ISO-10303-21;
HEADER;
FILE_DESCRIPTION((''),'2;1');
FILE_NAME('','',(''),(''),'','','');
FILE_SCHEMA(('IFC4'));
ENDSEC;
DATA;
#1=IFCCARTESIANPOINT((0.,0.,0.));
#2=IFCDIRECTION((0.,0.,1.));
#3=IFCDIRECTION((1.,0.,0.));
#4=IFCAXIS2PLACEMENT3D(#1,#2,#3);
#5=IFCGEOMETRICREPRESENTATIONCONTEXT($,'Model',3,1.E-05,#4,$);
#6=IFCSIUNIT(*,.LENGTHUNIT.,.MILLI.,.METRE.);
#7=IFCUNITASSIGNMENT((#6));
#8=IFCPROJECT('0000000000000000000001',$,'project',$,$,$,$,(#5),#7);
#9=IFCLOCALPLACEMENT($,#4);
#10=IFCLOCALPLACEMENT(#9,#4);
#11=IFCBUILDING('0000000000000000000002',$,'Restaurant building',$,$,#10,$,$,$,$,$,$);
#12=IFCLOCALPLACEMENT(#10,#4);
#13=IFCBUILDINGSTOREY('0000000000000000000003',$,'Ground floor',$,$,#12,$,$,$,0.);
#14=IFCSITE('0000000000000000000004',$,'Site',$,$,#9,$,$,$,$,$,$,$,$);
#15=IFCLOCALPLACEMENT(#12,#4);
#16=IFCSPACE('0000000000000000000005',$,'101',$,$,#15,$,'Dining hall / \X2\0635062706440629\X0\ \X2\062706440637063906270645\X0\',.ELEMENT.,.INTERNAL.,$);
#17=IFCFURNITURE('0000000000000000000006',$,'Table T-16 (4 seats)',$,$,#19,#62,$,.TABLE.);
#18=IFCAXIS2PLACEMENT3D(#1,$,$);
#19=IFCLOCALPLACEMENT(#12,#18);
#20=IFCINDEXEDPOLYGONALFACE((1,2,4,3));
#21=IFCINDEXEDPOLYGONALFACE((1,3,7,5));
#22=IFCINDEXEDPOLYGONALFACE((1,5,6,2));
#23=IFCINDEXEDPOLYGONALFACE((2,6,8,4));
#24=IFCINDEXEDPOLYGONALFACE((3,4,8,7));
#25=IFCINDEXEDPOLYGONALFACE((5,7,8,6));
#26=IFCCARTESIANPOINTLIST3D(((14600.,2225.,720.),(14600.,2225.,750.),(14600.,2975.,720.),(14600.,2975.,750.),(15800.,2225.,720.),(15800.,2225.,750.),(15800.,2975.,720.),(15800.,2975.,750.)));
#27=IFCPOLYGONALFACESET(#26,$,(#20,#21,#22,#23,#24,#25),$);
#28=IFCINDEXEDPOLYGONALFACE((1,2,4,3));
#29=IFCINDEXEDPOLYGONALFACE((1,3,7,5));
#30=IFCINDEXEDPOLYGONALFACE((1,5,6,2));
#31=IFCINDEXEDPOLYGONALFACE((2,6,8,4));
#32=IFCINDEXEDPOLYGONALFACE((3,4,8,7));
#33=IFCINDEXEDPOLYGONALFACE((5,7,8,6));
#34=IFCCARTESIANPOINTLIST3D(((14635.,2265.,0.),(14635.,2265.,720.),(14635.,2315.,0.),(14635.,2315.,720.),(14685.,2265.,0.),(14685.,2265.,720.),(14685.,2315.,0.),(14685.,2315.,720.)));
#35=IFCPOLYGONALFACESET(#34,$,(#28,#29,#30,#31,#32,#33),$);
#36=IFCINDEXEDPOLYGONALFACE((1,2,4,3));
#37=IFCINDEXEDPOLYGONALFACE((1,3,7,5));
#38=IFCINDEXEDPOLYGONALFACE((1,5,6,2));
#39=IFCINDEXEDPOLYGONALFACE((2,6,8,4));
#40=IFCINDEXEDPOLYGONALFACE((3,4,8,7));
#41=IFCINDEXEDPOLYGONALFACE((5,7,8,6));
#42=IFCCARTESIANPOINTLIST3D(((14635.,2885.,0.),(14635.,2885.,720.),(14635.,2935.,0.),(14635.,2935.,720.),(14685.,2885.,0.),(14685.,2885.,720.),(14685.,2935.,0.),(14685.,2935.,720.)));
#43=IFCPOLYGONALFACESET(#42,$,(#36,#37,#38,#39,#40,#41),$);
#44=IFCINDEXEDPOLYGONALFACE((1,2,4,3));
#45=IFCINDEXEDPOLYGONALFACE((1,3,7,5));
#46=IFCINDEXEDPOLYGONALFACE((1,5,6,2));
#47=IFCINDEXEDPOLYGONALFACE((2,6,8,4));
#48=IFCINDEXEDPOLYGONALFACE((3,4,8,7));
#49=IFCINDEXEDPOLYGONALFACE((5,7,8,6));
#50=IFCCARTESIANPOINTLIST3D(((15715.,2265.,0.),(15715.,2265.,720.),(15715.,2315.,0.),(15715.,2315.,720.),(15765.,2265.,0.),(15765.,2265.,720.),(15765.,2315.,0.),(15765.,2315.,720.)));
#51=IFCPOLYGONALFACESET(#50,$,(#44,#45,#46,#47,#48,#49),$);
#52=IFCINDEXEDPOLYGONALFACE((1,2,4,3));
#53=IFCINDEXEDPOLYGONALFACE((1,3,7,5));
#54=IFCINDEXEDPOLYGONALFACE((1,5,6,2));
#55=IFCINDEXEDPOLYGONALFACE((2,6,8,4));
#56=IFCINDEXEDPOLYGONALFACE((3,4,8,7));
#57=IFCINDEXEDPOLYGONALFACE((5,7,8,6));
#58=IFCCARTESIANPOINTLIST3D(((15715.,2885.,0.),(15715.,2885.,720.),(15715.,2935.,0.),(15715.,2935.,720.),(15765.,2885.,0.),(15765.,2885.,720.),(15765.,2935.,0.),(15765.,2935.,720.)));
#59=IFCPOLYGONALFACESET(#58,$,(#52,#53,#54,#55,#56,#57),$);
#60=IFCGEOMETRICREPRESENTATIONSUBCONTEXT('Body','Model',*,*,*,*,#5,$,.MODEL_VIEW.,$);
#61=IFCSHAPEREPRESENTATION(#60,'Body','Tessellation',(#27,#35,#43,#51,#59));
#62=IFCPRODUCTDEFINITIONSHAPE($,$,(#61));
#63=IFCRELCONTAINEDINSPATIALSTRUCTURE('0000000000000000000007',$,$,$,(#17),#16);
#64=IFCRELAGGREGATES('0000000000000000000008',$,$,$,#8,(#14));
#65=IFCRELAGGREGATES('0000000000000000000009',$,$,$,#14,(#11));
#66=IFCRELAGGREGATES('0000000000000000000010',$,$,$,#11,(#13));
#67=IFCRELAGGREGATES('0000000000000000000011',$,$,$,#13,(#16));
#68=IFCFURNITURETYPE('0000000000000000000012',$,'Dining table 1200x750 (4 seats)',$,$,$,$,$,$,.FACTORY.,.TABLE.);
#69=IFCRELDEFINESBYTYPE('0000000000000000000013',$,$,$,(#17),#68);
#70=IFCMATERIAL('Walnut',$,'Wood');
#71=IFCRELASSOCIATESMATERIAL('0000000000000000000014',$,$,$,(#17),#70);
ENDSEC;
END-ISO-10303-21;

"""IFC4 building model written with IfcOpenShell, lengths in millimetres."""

from ifc_helpers import new_model, si_unit, frame, origin, origin_with_axes, origin_2d, place, context, subcontext, project, spatial, rectangle, extrude, source, transform, mapped, material, type_object, type_shapes, element, save


model = new_model("IFC4")

# Units and contexts
model_context = context("Model", 3, precision=1e-05, world=origin_with_axes())
body_context = subcontext(model_context, "Body", "Model", "MODEL_VIEW")
ifc_project = project(units=[si_unit("LENGTHUNIT", "METRE", prefix="MILLI")], contexts=[model_context])

# Site, building, storey
site_placement = place(None, origin_with_axes())
site = spatial("IfcSite", under=ifc_project, at=site_placement, Name="Site")
building_placement = place(site_placement, origin_with_axes())
building = spatial("IfcBuilding", under=site, at=building_placement, Name="Restaurant building")
storey_placement = place(building_placement, origin_with_axes())
storey = spatial("IfcBuildingStorey", under=building, at=storey_placement, Name="Ground floor", Elevation=0.0)

# Shared definitions
space_placement = place(storey_placement, origin_with_axes())
space = spatial("IfcSpace", under=storey, at=space_placement, Name="101", LongName="Dining hall / صالة الطعام", CompositionType="ELEMENT", PredefinedType="INTERNAL")

# Furniture
ifc_material_1 = material(Name="Walnut", Category="Wood")
furniture_type_1 = type_object("IfcFurnitureType", Name="Dining table 1200x750 (4 seats)", AssemblyPlace="FACTORY", PredefinedType="TABLE")
shared_shape_1 = source(origin(), body_context, "Body", "SweptSolid", [
    extrude(rectangle(XDim=1200.0, YDim=750.0, at=origin_2d()), frame((0.0, 0.0, 720.0)), (0.0, 0.0, 1.0), 30.0),
    extrude(rectangle(XDim=50.0, YDim=50.0, at=origin_2d()), frame((-540.0, -310.0, 0.0)), (0.0, 0.0, 1.0), 720.0),
    extrude(rectangle(XDim=50.0, YDim=50.0, at=origin_2d()), frame((-540.0, 310.0, 0.0)), (0.0, 0.0, 1.0), 720.0),
    extrude(rectangle(XDim=50.0, YDim=50.0, at=origin_2d()), frame((540.0, -310.0, 0.0)), (0.0, 0.0, 1.0), 720.0),
    extrude(rectangle(XDim=50.0, YDim=50.0, at=origin_2d()), frame((540.0, 310.0, 0.0)), (0.0, 0.0, 1.0), 720.0),
])
type_shapes(furniture_type_1, [shared_shape_1])
furniture_1_placement = place(storey_placement, frame((15200.0, 2600.0, 0.0)))
element("IfcFurniture", 1, at=furniture_1_placement, inside=space, type_object=furniture_type_1, material=ifc_material_1, Name="Table T-16 (4 seats)", PredefinedType="TABLE", context=body_context, shape_type="MappedRepresentation", body=[
    mapped(shared_shape_1, transform((0.0, 0.0, 0.0))),
])

save(model, "model.ifc")
